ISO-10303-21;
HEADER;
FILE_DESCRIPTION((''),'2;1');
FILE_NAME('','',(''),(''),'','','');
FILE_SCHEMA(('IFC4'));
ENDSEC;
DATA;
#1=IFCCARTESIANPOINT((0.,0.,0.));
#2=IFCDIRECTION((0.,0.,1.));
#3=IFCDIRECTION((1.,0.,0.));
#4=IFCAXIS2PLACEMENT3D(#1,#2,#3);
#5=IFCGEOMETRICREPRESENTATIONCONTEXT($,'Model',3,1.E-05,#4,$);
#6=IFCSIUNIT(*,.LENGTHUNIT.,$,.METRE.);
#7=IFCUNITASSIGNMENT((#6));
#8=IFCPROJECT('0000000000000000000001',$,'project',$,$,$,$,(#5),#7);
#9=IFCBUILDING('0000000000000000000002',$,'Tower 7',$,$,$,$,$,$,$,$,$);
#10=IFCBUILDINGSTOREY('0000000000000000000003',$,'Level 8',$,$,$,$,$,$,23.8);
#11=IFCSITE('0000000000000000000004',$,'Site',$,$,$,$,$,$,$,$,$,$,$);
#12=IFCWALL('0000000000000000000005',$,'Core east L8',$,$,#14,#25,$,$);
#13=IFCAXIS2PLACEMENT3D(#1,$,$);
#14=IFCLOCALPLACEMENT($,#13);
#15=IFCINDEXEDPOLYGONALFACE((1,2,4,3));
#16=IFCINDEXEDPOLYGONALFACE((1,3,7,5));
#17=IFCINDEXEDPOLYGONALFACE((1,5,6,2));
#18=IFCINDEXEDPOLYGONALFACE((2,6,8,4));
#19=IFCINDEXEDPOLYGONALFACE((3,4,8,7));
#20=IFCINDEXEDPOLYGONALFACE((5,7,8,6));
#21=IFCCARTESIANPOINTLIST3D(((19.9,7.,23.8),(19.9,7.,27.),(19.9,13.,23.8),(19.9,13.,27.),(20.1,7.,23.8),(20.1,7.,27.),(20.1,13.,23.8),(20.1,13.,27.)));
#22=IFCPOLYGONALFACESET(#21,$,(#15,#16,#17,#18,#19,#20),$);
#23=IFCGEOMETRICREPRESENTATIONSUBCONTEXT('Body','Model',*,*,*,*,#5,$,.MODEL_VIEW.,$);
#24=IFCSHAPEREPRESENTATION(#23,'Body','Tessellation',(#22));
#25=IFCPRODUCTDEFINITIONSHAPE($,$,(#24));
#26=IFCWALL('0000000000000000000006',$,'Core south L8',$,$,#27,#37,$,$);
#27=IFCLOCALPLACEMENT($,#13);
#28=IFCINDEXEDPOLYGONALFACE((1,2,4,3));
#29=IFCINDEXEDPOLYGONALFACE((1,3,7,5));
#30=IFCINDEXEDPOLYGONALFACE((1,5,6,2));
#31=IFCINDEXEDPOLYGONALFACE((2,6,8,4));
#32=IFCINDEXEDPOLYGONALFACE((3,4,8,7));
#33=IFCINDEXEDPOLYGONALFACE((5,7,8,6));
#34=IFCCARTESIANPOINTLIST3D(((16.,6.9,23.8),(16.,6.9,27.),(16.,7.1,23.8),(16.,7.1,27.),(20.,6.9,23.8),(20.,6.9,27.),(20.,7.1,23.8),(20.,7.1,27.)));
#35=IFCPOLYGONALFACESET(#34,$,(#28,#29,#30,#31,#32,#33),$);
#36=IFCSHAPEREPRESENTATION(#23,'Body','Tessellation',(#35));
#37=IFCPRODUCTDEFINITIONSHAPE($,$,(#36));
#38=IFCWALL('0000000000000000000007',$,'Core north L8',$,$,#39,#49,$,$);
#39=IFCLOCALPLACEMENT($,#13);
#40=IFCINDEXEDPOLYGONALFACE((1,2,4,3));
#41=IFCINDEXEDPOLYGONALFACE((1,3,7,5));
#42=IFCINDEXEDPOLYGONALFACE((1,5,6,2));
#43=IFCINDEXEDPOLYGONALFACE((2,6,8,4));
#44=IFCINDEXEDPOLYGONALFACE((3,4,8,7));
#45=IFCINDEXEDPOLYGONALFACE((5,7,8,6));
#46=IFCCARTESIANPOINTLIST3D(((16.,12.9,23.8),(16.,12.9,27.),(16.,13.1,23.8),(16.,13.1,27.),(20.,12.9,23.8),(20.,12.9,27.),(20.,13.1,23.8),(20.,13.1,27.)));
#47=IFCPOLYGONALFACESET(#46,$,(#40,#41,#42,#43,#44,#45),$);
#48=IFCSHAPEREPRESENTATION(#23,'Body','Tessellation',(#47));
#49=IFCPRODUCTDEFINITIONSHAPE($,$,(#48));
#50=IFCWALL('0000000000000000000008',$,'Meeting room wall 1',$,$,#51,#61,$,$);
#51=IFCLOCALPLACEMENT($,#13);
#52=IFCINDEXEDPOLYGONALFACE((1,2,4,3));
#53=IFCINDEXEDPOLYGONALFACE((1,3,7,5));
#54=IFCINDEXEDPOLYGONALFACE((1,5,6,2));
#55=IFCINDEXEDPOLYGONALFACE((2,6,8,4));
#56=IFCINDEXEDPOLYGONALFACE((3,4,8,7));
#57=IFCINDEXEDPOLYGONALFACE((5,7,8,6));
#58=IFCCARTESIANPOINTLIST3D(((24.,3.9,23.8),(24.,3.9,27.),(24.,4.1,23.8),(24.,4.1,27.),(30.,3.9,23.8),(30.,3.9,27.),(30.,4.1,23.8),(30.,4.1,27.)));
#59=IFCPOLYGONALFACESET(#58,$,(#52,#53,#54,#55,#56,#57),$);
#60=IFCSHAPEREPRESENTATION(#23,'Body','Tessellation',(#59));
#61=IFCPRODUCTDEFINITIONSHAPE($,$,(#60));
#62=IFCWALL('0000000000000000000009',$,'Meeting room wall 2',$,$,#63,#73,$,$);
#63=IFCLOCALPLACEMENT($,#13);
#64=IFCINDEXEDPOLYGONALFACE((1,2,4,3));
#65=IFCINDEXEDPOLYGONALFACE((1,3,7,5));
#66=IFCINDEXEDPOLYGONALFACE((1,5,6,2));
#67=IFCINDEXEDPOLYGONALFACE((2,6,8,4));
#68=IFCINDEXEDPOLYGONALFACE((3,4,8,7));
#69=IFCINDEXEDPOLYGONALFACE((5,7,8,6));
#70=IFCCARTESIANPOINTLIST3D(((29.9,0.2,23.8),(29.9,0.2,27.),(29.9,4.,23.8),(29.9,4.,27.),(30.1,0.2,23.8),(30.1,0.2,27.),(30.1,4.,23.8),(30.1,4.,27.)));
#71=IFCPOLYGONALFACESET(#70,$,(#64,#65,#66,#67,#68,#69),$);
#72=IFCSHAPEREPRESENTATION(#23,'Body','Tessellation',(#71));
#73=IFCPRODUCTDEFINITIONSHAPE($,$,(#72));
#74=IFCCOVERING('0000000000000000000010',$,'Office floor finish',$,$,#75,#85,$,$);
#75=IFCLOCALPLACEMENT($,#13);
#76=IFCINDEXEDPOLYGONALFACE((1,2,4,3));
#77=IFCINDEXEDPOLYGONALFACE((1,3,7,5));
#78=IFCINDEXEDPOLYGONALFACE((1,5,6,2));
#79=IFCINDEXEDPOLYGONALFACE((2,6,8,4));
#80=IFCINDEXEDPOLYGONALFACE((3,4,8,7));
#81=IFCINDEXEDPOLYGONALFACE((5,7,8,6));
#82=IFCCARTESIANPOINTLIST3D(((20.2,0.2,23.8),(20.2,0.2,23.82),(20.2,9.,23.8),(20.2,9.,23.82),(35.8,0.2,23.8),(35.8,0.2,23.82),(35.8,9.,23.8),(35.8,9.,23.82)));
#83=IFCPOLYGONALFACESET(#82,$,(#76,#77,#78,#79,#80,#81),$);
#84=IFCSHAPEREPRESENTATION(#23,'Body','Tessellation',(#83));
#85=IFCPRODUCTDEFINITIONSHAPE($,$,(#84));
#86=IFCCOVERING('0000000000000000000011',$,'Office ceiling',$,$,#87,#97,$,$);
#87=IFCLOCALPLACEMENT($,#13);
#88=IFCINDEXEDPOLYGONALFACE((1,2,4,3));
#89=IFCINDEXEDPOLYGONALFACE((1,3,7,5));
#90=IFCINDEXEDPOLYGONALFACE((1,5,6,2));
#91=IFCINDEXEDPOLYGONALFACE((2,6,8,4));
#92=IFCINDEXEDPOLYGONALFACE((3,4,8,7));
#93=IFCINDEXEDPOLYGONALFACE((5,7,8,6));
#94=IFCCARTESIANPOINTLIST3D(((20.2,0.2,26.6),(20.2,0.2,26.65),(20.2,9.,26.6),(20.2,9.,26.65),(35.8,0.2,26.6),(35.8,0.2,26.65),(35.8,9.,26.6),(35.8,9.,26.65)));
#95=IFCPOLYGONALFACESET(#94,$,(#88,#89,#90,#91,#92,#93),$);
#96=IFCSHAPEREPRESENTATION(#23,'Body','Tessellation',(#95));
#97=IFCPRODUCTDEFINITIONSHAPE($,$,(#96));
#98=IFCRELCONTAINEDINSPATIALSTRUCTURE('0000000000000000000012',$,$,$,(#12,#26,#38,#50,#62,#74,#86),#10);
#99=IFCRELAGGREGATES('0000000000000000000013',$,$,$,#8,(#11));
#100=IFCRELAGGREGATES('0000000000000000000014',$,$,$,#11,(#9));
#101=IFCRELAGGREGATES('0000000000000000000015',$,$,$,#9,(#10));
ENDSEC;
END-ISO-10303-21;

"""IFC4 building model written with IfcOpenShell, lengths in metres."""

from ifc_helpers import new_model, si_unit, frame, origin, origin_with_axes, origin_2d, place, context, subcontext, project, spatial, rectangle, extrude, element, save


model = new_model("IFC4")

# Units and contexts
model_context = context("Model", 3, precision=1e-05, world=origin_with_axes())
body_context = subcontext(model_context, "Body", "Model", "MODEL_VIEW")
ifc_project = project(units=[si_unit("LENGTHUNIT", "METRE")], contexts=[model_context])

# Site, building, storey
site = spatial("IfcSite", under=ifc_project, Name="Site")
building = spatial("IfcBuilding", under=site, Name="Tower 7")
storey = spatial("IfcBuildingStorey", under=building, Name="Level 8", Elevation=23.8)

# Walls
wall_1_placement = place(None, frame((20.0, 10.0, 23.8), z_axis=(0.0, 0.0, 1.0), x_axis=(1.0, 0.0, 0.0)))
element("IfcWall", 1, at=wall_1_placement, inside=storey, Name="Core east L8", context=body_context, shape_type="SweptSolid", body=[
    extrude(rectangle(XDim=0.2, YDim=6.0, at=origin_2d()), origin(), (0.0, 0.0, 1.0), 3.2),
])
for number, where, z_axis, x_axis, name in (
    (2, (18.0, 7.0, 23.8), (0.0, 0.0, 1.0), (1.0, 0.0, 0.0), "Core south L8"),
    (3, (18.0, 13.0, 23.8), (0.0, 0.0, 1.0), (1.0, 0.0, 0.0), "Core north L8"),
):
    element("IfcWall", number, at=place(None, frame(where, z_axis=z_axis, x_axis=x_axis)), inside=storey, Name=name, context=body_context, shape_type="SweptSolid", body=[
        extrude(rectangle(XDim=4.0, YDim=0.2, at=origin_2d()), origin(), (0.0, 0.0, 1.0), 3.2),
    ])
wall_2_placement = place(None, frame((27.0, 4.0, 23.8), z_axis=(0.0, 0.0, 1.0), x_axis=(1.0, 0.0, 0.0)))
element("IfcWall", 4, at=wall_2_placement, inside=storey, Name="Meeting room wall 1", context=body_context, shape_type="SweptSolid", body=[
    extrude(rectangle(XDim=6.0, YDim=0.2, at=origin_2d()), origin(), (0.0, 0.0, 1.0), 3.2),
])
wall_3_placement = place(None, frame((30.0, 2.1, 23.8), z_axis=(0.0, 0.0, 1.0), x_axis=(1.0, 0.0, 0.0)))
element("IfcWall", 5, at=wall_3_placement, inside=storey, Name="Meeting room wall 2", context=body_context, shape_type="SweptSolid", body=[
    extrude(rectangle(XDim=0.2, YDim=3.8, at=origin_2d()), origin(), (0.0, 0.0, 1.0), 3.2),
])

# Coverings
covering_1_placement = place(None, frame((28.0, 4.6, 23.8), z_axis=(0.0, 0.0, 1.0), x_axis=(1.0, 0.0, 0.0)))
element("IfcCovering", 6, at=covering_1_placement, inside=storey, Name="Office floor finish", context=body_context, shape_type="SweptSolid", body=[
    extrude(rectangle(XDim=15.6, YDim=8.8, at=origin_2d()), origin(), (0.0, 0.0, 1.0), 0.02),
])
covering_2_placement = place(None, frame((28.0, 4.6, 26.6), z_axis=(0.0, 0.0, 1.0), x_axis=(1.0, 0.0, 0.0)))
element("IfcCovering", 7, at=covering_2_placement, inside=storey, Name="Office ceiling", context=body_context, shape_type="SweptSolid", body=[
    extrude(rectangle(XDim=15.6, YDim=8.8, at=origin_2d()), origin(), (0.0, 0.0, 1.0), 0.05),
])

save(model, "model.ifc")
